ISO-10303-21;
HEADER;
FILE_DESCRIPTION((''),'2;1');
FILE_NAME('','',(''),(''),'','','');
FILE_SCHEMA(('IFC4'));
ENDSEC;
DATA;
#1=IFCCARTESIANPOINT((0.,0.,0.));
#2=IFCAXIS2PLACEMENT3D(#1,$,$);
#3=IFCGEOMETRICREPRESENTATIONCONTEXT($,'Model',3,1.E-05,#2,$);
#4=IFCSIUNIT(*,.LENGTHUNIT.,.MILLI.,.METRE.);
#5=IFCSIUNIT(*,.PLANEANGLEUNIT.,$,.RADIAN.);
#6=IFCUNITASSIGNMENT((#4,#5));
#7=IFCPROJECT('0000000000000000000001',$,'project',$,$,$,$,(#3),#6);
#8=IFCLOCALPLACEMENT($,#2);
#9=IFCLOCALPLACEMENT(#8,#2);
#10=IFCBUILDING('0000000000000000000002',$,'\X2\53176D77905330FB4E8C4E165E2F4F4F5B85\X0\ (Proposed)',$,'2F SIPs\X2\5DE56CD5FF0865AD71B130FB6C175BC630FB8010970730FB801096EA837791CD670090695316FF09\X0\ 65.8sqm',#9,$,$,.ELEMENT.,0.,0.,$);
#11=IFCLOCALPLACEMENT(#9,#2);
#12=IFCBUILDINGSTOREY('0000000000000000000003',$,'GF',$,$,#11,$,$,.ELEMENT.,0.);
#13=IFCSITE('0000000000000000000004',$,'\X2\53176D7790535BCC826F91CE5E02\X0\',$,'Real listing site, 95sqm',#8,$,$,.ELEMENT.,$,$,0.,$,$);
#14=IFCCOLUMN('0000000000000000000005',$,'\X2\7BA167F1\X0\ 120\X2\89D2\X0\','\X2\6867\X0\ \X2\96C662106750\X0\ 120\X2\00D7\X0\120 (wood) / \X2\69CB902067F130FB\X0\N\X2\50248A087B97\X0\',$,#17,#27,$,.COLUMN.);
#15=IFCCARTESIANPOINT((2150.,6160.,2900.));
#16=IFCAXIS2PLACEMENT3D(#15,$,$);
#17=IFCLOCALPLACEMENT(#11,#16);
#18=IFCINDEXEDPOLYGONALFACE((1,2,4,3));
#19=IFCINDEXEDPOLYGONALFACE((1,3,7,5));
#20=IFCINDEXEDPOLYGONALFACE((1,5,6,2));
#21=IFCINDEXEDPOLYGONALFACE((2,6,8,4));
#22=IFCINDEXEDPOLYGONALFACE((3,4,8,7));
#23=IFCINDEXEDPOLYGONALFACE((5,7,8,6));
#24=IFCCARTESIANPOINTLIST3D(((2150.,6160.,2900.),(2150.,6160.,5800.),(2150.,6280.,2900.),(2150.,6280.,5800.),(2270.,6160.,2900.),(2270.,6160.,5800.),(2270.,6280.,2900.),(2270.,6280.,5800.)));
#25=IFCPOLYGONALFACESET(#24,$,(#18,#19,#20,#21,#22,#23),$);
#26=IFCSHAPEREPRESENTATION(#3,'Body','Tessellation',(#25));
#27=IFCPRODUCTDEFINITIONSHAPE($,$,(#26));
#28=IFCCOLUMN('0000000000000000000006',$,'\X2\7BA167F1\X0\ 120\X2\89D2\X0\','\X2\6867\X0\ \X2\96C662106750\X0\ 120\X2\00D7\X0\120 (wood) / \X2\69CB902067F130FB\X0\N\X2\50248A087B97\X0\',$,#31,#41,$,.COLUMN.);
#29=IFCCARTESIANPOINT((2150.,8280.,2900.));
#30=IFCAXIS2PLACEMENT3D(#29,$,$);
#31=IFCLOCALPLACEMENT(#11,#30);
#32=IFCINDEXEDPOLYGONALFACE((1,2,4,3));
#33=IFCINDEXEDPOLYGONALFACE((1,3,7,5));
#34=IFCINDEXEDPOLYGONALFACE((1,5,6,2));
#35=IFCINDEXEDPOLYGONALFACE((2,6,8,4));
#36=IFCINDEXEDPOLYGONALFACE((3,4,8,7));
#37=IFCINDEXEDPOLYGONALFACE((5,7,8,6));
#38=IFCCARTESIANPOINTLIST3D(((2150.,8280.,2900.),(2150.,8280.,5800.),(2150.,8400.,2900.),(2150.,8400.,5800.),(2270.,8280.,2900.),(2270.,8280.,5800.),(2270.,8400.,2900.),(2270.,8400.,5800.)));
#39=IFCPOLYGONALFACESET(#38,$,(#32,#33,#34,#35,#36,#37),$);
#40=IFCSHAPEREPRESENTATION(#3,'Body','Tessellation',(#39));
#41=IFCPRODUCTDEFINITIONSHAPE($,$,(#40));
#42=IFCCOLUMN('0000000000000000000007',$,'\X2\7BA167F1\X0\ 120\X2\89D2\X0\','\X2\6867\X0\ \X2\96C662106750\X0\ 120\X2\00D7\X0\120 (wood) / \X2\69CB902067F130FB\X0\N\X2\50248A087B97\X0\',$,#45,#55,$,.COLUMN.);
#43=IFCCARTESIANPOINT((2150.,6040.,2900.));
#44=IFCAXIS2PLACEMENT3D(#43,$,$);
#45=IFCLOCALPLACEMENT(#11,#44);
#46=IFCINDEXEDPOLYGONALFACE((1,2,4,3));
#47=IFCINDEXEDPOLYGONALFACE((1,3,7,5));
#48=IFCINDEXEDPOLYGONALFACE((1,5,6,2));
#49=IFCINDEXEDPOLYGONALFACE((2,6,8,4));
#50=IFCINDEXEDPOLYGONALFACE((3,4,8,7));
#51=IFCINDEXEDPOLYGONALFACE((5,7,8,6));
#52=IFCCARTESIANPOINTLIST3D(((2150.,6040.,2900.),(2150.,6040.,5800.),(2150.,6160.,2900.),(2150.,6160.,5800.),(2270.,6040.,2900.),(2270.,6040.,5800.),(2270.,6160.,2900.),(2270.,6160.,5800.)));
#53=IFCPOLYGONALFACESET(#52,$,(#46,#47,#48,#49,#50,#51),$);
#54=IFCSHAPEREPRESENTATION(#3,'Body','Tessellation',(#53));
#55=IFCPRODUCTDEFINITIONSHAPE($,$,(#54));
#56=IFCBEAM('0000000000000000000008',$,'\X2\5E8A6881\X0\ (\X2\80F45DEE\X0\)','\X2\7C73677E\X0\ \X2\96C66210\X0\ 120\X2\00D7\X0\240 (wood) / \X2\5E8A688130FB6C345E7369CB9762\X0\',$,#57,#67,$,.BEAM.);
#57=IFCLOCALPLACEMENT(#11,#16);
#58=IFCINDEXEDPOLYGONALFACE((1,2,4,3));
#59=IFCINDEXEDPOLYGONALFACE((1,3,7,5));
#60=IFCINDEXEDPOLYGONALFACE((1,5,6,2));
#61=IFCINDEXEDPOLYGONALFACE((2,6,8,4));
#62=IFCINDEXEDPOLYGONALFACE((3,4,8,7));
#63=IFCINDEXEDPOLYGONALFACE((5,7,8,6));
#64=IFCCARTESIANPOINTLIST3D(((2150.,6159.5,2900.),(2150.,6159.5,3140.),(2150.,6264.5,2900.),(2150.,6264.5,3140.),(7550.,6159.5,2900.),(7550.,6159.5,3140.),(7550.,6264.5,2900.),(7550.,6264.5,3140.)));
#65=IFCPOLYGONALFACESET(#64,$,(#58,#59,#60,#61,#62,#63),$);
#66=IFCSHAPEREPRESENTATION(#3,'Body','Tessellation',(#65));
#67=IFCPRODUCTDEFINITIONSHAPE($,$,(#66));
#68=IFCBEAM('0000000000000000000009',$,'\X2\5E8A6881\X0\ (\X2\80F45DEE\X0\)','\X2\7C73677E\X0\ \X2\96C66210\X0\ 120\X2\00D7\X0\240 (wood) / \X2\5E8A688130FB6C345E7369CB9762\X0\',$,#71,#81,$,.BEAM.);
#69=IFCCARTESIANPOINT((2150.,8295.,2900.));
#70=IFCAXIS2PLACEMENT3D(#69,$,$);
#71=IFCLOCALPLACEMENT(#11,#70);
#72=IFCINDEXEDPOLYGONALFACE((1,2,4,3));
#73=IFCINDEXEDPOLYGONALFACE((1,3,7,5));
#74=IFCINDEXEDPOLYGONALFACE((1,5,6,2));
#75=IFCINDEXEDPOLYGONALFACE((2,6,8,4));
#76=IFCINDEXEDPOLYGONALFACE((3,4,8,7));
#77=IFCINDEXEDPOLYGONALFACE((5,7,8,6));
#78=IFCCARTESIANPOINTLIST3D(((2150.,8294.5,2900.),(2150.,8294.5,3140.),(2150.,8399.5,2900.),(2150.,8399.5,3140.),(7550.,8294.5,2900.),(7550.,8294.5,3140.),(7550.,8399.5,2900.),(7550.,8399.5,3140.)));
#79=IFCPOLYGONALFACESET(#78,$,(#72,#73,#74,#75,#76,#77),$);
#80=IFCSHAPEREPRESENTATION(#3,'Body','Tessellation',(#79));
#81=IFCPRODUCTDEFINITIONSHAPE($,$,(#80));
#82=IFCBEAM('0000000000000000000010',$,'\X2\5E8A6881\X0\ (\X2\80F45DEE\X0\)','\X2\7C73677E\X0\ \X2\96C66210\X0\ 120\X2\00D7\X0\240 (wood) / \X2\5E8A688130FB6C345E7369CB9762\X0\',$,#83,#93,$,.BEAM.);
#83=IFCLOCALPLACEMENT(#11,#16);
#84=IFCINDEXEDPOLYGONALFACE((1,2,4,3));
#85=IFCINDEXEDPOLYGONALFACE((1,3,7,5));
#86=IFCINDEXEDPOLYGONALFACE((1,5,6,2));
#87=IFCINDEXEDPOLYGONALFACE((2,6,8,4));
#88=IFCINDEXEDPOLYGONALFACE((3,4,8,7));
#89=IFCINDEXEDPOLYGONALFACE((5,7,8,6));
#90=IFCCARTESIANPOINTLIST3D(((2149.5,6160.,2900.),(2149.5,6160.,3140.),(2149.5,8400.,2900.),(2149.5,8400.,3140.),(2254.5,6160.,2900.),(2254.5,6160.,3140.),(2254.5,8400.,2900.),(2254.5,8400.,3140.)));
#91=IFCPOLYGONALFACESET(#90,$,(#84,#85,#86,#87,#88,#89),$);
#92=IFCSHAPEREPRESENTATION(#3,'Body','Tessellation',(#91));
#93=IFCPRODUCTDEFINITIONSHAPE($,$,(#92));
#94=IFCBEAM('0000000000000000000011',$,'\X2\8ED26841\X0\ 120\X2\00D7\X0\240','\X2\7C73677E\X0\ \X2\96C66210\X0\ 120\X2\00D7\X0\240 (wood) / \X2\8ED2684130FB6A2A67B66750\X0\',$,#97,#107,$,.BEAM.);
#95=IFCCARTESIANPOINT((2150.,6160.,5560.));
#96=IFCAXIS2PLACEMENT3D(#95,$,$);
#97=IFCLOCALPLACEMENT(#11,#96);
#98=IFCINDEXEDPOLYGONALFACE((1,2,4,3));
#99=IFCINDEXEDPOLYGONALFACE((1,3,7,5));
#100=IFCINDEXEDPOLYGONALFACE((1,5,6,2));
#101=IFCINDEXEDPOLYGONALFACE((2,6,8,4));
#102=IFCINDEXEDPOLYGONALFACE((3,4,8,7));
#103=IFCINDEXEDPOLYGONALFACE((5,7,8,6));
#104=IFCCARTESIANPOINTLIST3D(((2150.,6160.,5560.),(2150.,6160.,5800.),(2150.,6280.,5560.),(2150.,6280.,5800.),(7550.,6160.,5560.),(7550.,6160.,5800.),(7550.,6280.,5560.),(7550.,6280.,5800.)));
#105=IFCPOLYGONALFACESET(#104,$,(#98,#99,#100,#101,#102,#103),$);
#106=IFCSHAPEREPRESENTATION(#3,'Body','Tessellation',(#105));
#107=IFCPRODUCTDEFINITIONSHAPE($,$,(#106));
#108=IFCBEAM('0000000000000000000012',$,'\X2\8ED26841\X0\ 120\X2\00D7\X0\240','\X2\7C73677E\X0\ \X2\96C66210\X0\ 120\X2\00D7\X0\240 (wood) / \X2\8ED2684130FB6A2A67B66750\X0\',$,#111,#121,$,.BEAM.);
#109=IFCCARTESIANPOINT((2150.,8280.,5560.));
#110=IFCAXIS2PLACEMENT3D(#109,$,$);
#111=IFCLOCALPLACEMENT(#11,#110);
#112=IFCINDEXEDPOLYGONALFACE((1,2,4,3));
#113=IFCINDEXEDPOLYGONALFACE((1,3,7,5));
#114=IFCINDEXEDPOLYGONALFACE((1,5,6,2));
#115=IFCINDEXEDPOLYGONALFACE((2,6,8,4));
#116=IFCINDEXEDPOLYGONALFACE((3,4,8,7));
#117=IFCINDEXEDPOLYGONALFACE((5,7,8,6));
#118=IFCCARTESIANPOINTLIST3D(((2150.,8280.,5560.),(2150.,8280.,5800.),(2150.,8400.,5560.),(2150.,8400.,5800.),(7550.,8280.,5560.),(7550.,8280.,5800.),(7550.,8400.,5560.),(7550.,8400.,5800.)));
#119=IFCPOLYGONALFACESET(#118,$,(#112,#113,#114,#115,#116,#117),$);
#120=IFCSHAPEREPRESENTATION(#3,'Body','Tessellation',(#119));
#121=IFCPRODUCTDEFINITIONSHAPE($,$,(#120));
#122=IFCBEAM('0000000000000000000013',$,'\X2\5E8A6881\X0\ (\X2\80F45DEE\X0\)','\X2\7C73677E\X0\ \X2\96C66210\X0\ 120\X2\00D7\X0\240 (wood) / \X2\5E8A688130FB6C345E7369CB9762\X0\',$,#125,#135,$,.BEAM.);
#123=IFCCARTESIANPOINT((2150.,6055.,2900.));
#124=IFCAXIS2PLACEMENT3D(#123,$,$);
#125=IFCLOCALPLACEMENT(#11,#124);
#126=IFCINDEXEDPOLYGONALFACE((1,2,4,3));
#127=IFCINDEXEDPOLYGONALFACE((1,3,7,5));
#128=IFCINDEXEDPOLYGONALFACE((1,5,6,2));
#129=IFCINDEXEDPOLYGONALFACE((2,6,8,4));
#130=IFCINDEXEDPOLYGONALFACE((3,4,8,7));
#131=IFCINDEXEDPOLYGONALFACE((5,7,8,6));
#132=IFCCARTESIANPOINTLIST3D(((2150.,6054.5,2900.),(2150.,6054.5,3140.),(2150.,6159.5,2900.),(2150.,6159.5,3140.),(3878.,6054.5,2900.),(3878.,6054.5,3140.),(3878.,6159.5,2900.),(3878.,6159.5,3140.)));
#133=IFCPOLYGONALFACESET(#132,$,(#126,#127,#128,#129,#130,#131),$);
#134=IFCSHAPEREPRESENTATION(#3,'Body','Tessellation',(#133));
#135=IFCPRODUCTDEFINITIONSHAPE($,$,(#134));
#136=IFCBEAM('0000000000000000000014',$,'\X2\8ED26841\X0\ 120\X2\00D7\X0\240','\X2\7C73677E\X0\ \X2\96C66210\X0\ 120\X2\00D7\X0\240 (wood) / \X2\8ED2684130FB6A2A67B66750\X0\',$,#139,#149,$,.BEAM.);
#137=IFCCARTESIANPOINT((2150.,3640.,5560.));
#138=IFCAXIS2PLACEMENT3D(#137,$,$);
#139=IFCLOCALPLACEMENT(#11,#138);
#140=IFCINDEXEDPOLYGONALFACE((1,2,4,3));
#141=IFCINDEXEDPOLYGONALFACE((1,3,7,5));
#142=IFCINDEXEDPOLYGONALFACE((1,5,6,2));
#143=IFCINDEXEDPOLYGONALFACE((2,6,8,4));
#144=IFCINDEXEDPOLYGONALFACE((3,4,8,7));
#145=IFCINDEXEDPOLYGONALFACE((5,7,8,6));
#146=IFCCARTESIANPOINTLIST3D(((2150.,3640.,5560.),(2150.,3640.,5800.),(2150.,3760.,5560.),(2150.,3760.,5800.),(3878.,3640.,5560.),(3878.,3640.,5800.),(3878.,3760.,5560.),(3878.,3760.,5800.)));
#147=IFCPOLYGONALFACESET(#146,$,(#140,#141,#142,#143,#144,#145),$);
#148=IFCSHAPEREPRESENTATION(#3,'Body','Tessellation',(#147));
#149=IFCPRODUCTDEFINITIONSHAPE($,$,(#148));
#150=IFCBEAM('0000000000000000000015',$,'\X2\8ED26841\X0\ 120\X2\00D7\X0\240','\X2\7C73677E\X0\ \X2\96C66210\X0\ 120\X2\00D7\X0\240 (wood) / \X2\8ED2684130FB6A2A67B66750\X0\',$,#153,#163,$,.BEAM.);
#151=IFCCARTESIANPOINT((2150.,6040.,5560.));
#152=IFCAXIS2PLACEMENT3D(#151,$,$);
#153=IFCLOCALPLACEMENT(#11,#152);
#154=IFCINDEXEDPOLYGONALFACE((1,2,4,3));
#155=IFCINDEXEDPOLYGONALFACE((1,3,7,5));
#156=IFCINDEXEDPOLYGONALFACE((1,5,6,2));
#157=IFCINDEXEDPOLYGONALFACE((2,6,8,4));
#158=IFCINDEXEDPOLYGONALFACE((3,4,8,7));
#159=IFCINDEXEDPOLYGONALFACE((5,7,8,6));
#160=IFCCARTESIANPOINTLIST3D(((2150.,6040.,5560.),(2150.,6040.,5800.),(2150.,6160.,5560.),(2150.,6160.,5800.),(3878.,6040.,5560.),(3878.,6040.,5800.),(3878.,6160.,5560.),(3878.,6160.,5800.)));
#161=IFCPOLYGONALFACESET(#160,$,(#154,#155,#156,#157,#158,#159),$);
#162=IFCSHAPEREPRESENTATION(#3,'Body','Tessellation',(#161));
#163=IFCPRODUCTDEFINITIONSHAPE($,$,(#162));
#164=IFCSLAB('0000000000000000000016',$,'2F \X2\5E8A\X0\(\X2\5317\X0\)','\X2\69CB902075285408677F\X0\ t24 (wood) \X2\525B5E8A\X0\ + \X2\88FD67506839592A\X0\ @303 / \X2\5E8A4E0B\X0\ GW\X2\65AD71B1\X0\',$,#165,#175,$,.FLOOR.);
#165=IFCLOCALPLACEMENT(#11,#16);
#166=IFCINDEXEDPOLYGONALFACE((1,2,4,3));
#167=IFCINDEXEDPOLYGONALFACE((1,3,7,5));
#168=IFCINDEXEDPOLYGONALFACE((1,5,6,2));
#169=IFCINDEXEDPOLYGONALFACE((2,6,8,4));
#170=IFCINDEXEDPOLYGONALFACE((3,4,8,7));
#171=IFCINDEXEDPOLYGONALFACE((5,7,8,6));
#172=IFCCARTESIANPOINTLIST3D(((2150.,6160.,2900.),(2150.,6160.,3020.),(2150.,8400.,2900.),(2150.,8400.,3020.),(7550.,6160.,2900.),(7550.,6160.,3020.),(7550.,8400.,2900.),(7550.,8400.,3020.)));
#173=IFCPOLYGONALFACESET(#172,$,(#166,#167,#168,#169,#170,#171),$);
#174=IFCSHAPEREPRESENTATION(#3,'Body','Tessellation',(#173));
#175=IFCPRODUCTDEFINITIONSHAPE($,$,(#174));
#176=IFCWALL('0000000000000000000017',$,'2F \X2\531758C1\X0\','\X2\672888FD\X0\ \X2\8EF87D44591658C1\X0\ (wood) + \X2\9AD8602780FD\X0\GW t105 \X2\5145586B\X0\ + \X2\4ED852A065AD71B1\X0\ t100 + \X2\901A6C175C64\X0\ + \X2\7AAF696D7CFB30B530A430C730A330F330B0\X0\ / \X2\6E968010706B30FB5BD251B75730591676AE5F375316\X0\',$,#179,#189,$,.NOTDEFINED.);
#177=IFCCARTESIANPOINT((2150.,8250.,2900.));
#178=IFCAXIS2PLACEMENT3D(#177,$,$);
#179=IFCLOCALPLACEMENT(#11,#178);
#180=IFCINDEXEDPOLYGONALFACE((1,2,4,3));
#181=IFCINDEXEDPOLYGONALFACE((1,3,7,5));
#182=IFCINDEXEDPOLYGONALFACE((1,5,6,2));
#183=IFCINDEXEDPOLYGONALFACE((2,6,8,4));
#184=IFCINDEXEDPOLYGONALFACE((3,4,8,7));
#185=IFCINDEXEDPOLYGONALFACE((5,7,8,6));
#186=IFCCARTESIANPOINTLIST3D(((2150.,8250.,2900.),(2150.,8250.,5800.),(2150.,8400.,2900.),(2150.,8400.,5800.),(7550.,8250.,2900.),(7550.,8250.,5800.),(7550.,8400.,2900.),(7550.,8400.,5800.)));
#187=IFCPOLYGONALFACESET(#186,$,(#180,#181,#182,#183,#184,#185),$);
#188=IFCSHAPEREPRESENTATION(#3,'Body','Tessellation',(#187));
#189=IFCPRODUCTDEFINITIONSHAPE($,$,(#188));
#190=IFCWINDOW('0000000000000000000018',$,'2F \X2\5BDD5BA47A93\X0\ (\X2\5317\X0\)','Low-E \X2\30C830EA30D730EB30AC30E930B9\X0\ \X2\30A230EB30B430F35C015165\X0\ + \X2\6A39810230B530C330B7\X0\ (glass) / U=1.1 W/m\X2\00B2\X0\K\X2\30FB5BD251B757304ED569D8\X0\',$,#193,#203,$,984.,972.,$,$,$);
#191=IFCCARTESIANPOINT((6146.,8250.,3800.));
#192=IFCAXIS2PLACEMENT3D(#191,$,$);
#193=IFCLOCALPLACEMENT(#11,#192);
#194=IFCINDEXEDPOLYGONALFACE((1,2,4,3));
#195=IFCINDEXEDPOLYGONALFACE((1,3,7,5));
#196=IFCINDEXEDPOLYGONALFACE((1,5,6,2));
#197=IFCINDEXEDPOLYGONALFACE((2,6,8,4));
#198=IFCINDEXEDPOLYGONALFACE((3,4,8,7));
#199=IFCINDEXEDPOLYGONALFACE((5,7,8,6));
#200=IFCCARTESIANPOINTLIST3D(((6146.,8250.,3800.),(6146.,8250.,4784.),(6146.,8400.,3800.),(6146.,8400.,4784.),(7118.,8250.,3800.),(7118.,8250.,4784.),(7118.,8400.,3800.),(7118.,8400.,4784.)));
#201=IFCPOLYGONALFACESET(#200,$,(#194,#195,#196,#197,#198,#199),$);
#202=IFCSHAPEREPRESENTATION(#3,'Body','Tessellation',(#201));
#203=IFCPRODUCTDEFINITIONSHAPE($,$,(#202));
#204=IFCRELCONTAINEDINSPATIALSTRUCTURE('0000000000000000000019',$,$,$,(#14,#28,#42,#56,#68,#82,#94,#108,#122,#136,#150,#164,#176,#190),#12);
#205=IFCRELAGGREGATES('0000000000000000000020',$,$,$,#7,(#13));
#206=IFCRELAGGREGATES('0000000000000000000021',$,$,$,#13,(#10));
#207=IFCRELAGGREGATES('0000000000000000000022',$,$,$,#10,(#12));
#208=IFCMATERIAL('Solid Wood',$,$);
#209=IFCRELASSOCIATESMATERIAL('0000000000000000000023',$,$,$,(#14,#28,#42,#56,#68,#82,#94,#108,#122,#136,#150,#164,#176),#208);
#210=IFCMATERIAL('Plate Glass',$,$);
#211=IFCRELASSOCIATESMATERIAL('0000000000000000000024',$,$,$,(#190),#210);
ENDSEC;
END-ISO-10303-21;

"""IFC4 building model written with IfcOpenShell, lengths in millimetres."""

from ifc_helpers import new_model, si_unit, frame, frame_2d, origin, place, context, project, spatial, rectangle, extrude, material, element, fill, save


model = new_model("IFC4")

# Units and contexts
model_context = context("Model", 3, precision=1e-05, world=origin())
ifc_project = project(units=[si_unit("LENGTHUNIT", "METRE", prefix="MILLI"), si_unit("PLANEANGLEUNIT", "RADIAN")], contexts=[model_context])

# Site, building, storey
site_placement = place(None, origin())
site = spatial("IfcSite", under=ifc_project, at=site_placement, Name="北海道富良野市", ObjectType="Real listing site, 95sqm", CompositionType="ELEMENT", RefElevation=0.0)
building_placement = place(site_placement, origin())
building = spatial("IfcBuilding", under=site, at=building_placement, Name="北海道・二世帯住宅 (Proposed)", ObjectType="2F SIPs工法（断熱・気密・耐震・耐雪荷重最適化） 65.8sqm", CompositionType="ELEMENT", ElevationOfRefHeight=0.0, ElevationOfTerrain=0.0)
storey_placement = place(building_placement, origin())
storey = spatial("IfcBuildingStorey", under=building, at=storey_placement, Name="GF", CompositionType="ELEMENT", Elevation=0.0)

# Columns
ifc_material_1 = material(Name="Solid Wood")
column_1_placement = place(storey_placement, frame((2150.0, 6160.0, 2900.0)))
element("IfcColumn", 1, at=column_1_placement, inside=storey, material=ifc_material_1, Name="管柱 120角", Description="桧 集成材 120×120 (wood) / 構造柱・N値計算", PredefinedType="COLUMN", context=model_context, shape_type="SweptSolid", body=[
    extrude(rectangle(XDim=120.0, YDim=120.0, at=frame_2d((60.0, 60.0))), frame((2150.0, 6160.0, 2900.0)), (0.0, 0.0, 1.0), 2900.0),
])
column_2_placement = place(storey_placement, frame((2150.0, 8280.0, 2900.0)))
element("IfcColumn", 2, at=column_2_placement, inside=storey, material=ifc_material_1, Name="管柱 120角", Description="桧 集成材 120×120 (wood) / 構造柱・N値計算", PredefinedType="COLUMN", context=model_context, shape_type="SweptSolid", body=[
    extrude(rectangle(XDim=120.0, YDim=120.0, at=frame_2d((60.0, 60.0))), frame((2150.0, 8280.0, 2900.0)), (0.0, 0.0, 1.0), 2900.0),
])
column_3_placement = place(storey_placement, frame((2150.0, 6040.0, 2900.0)))
element("IfcColumn", 3, at=column_3_placement, inside=storey, material=ifc_material_1, Name="管柱 120角", Description="桧 集成材 120×120 (wood) / 構造柱・N値計算", PredefinedType="COLUMN", context=model_context, shape_type="SweptSolid", body=[
    extrude(rectangle(XDim=120.0, YDim=120.0, at=frame_2d((60.0, 60.0))), frame((2150.0, 6040.0, 2900.0)), (0.0, 0.0, 1.0), 2900.0),
])

# Beams
beam_1_placement = place(storey_placement, frame((2150.0, 6160.0, 2900.0)))
element("IfcBeam", 4, at=beam_1_placement, inside=storey, material=ifc_material_1, Name="床梁 (胴差)", Description="米松 集成 120×240 (wood) / 床梁・水平構面", PredefinedType="BEAM", context=model_context, shape_type="SweptSolid", body=[
    extrude(rectangle(XDim=5400.0, YDim=105.0, at=frame_2d((2700.0, 52.0))), frame((2150.0, 6160.0, 2900.0)), (0.0, 0.0, 1.0), 240.0),
])
beam_2_placement = place(storey_placement, frame((2150.0, 8295.0, 2900.0)))
element("IfcBeam", 5, at=beam_2_placement, inside=storey, material=ifc_material_1, Name="床梁 (胴差)", Description="米松 集成 120×240 (wood) / 床梁・水平構面", PredefinedType="BEAM", context=model_context, shape_type="SweptSolid", body=[
    extrude(rectangle(XDim=5400.0, YDim=105.0, at=frame_2d((2700.0, 52.0))), frame((2150.0, 8295.0, 2900.0)), (0.0, 0.0, 1.0), 240.0),
])
beam_3_placement = place(storey_placement, frame((2150.0, 6160.0, 2900.0)))
element("IfcBeam", 6, at=beam_3_placement, inside=storey, material=ifc_material_1, Name="床梁 (胴差)", Description="米松 集成 120×240 (wood) / 床梁・水平構面", PredefinedType="BEAM", context=model_context, shape_type="SweptSolid", body=[
    extrude(rectangle(XDim=105.0, YDim=2240.0, at=frame_2d((52.0, 1120.0))), frame((2150.0, 6160.0, 2900.0)), (0.0, 0.0, 1.0), 240.0),
])
beam_4_placement = place(storey_placement, frame((2150.0, 6160.0, 5560.0)))
element("IfcBeam", 7, at=beam_4_placement, inside=storey, material=ifc_material_1, Name="軒桁 120×240", Description="米松 集成 120×240 (wood) / 軒桁・横架材", PredefinedType="BEAM", context=model_context, shape_type="SweptSolid", body=[
    extrude(rectangle(XDim=5400.0, YDim=120.0, at=frame_2d((2700.0, 60.0))), frame((2150.0, 6160.0, 5560.0)), (0.0, 0.0, 1.0), 240.0),
])
beam_5_placement = place(storey_placement, frame((2150.0, 8280.0, 5560.0)))
element("IfcBeam", 8, at=beam_5_placement, inside=storey, material=ifc_material_1, Name="軒桁 120×240", Description="米松 集成 120×240 (wood) / 軒桁・横架材", PredefinedType="BEAM", context=model_context, shape_type="SweptSolid", body=[
    extrude(rectangle(XDim=5400.0, YDim=120.0, at=frame_2d((2700.0, 60.0))), frame((2150.0, 8280.0, 5560.0)), (0.0, 0.0, 1.0), 240.0),
])
beam_6_placement = place(storey_placement, frame((2150.0, 6055.0, 2900.0)))
element("IfcBeam", 9, at=beam_6_placement, inside=storey, material=ifc_material_1, Name="床梁 (胴差)", Description="米松 集成 120×240 (wood) / 床梁・水平構面", PredefinedType="BEAM", context=model_context, shape_type="SweptSolid", body=[
    extrude(rectangle(XDim=1728.0, YDim=105.0, at=frame_2d((864.0, 52.0))), frame((2150.0, 6055.0, 2900.0)), (0.0, 0.0, 1.0), 240.0),
])
beam_7_placement = place(storey_placement, frame((2150.0, 3640.0, 5560.0)))
element("IfcBeam", 10, at=beam_7_placement, inside=storey, material=ifc_material_1, Name="軒桁 120×240", Description="米松 集成 120×240 (wood) / 軒桁・横架材", PredefinedType="BEAM", context=model_context, shape_type="SweptSolid", body=[
    extrude(rectangle(XDim=1728.0, YDim=120.0, at=frame_2d((864.0, 60.0))), frame((2150.0, 3640.0, 5560.0)), (0.0, 0.0, 1.0), 240.0),
])
beam_8_placement = place(storey_placement, frame((2150.0, 6040.0, 5560.0)))
element("IfcBeam", 11, at=beam_8_placement, inside=storey, material=ifc_material_1, Name="軒桁 120×240", Description="米松 集成 120×240 (wood) / 軒桁・横架材", PredefinedType="BEAM", context=model_context, shape_type="SweptSolid", body=[
    extrude(rectangle(XDim=1728.0, YDim=120.0, at=frame_2d((864.0, 60.0))), frame((2150.0, 6040.0, 5560.0)), (0.0, 0.0, 1.0), 240.0),
])

# Slab
slab_placement = place(storey_placement, frame((2150.0, 6160.0, 2900.0)))
element("IfcSlab", 12, at=slab_placement, inside=storey, material=ifc_material_1, Name="2F 床(北)", Description="構造用合板 t24 (wood) 剛床 + 製材根太 @303 / 床下 GW断熱", PredefinedType="FLOOR", context=model_context, shape_type="SweptSolid", body=[
    extrude(rectangle(XDim=5400.0, YDim=2240.0, at=frame_2d((2700.0, 1120.0))), frame((2150.0, 6160.0, 2900.0)), (0.0, 0.0, 1.0), 120.0),
])

# Wall, opening, window
wall_placement = place(storey_placement, frame((2150.0, 8250.0, 2900.0)))
wall = element("IfcWall", 13, at=wall_placement, inside=storey, material=ifc_material_1, Name="2F 北壁", Description="木製 軸組外壁 (wood) + 高性能GW t105 充填 + 付加断熱 t100 + 通気層 + 窯業系サイディング / 準耐火・寒冷地外皮強化", PredefinedType="NOTDEFINED", context=model_context, shape_type="SweptSolid", body=[
    extrude(rectangle(XDim=5400.0, YDim=150.0, at=frame_2d((2700.0, 75.0))), frame((2150.0, 8250.0, 2900.0)), (0.0, 0.0, 1.0), 2900.0),
])
opening_placement = place(storey_placement, frame((6146.0, 8250.0, 3800.0)))
opening = element("IfcOpeningElement", 14, at=opening_placement, cuts=wall, PredefinedType="NOTDEFINED", context=model_context, shape_type="SweptSolid", body=[
    extrude(rectangle(XDim=972.0, YDim=150.0, at=frame_2d((486.0, 75.0))), frame((6146.0, 8250.0, 3800.0)), (0.0, 0.0, 1.0), 984.0),
])
ifc_material_2 = material(Name="Plate Glass")
window_placement = place(storey_placement, frame((6146.0, 8250.0, 3800.0)))
window = element("IfcWindow", 15, at=window_placement, inside=storey, material=ifc_material_2, Name="2F 寝室窓 (北)", Description="Low-E トリプルガラス アルゴン封入 + 樹脂サッシ (glass) / U=1.1 W/m²K・寒冷地仕様", OverallHeight=984.0, OverallWidth=972.0, context=model_context, shape_type="SweptSolid", body=[
    extrude(rectangle(XDim=972.0, YDim=150.0, at=frame_2d((486.0, 75.0))), frame((6146.0, 8250.0, 3800.0)), (0.0, 0.0, 1.0), 984.0),
])
fill(opening, window)

save(model, "model.ifc")
